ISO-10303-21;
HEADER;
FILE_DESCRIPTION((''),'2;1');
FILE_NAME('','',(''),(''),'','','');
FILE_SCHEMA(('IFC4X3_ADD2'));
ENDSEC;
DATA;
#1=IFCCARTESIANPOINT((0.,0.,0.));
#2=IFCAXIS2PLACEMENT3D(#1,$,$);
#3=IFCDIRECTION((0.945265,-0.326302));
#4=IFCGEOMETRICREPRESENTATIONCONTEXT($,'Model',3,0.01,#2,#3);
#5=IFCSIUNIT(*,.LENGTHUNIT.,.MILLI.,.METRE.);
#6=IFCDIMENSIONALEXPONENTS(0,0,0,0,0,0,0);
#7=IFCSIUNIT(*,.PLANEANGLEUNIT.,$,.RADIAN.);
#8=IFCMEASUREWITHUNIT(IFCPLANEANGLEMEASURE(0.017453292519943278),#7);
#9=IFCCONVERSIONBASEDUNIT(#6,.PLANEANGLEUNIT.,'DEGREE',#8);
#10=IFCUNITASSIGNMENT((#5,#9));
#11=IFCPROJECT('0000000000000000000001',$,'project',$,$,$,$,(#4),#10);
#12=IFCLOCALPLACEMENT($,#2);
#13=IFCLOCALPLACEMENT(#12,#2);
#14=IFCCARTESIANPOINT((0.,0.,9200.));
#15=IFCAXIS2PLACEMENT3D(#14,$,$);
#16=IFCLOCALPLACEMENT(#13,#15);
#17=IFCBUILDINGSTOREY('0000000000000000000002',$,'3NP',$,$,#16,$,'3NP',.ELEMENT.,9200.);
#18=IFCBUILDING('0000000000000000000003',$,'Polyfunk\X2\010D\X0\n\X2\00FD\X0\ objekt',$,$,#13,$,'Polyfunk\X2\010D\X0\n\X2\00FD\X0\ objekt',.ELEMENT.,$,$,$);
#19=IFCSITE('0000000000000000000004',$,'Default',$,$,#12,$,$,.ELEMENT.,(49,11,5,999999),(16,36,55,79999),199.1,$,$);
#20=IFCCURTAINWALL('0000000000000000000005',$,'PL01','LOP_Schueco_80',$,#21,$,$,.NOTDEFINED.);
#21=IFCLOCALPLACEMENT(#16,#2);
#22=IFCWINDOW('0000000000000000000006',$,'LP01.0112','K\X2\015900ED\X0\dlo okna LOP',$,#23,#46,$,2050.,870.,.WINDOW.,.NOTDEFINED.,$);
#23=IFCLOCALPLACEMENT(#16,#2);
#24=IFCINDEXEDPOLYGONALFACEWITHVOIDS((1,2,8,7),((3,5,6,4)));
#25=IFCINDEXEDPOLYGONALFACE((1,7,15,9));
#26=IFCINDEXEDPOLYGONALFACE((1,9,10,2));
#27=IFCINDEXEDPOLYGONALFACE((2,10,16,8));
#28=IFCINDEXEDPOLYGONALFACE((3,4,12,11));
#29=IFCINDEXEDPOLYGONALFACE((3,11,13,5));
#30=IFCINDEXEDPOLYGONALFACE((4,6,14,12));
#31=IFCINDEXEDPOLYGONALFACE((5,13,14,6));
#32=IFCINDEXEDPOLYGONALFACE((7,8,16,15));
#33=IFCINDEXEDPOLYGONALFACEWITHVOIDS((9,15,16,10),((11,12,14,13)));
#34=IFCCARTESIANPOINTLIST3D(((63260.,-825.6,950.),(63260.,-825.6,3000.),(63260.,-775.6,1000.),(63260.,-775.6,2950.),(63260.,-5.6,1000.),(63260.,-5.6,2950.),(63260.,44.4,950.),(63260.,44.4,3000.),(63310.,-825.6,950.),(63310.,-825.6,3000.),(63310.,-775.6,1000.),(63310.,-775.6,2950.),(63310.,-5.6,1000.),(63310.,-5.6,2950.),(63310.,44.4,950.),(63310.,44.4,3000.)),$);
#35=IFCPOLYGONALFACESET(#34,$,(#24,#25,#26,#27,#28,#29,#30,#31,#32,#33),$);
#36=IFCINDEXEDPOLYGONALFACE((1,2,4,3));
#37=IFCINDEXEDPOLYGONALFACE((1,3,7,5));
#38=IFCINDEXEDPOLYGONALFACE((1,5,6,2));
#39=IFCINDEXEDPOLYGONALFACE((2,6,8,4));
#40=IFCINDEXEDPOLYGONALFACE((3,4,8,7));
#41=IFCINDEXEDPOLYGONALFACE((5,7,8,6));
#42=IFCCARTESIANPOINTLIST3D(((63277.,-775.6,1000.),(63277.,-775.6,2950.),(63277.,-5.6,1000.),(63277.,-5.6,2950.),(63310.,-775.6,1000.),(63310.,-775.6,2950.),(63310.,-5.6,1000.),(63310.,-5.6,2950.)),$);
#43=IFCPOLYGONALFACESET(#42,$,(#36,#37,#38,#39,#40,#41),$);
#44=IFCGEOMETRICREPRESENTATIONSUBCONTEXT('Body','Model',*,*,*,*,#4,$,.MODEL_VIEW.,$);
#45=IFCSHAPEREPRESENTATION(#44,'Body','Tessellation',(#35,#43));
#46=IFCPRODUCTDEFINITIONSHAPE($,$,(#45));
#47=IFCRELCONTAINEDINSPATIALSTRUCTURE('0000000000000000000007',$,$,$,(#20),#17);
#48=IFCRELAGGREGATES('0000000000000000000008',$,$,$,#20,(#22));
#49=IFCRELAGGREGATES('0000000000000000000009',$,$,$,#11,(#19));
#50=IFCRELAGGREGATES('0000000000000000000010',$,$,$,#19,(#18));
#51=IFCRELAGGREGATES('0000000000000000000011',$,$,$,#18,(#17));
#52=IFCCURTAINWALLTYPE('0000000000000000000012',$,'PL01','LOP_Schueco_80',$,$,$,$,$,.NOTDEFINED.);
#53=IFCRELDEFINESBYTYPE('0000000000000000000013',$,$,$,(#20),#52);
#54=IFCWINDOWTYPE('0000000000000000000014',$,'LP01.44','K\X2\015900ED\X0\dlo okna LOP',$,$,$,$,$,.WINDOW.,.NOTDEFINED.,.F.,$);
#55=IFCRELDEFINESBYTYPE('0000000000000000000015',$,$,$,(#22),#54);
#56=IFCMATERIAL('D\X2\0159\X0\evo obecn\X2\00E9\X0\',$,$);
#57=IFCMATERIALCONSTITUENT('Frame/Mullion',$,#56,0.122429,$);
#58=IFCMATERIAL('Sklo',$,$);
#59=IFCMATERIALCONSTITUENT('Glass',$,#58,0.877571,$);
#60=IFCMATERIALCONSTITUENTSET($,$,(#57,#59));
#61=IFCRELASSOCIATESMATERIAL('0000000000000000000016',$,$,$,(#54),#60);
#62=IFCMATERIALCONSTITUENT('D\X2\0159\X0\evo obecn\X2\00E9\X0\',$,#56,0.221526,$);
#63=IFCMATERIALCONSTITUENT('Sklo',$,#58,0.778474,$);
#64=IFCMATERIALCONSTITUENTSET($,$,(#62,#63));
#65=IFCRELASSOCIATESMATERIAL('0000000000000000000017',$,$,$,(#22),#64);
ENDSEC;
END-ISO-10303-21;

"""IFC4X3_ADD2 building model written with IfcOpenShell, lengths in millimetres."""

from ifc_helpers import new_model, entity, si_unit, converted_unit, direction, frame, origin, origin_2d_with_axis, place, context, subcontext, project, spatial, polyline, rectangle, outline, extrude, source, transform, mapped, material, constituent, constituent_set, type_object, type_shapes, element, aggregate, save


model = new_model("IFC4X3_ADD2")

# Units and contexts
model_context = context("Model", 3, precision=0.01, world=origin(), true_north=direction((0.945265, -0.326302)))
body_context = subcontext(model_context, "Body", "Model", "MODEL_VIEW")
ifc_project = project(units=[si_unit("LENGTHUNIT", "METRE", prefix="MILLI"), converted_unit("PLANEANGLEUNIT", "DEGREE", entity("IfcPlaneAngleMeasure", 0.017453292519943278), si_unit("PLANEANGLEUNIT", "RADIAN"), dimensions=[0, 0, 0, 0, 0, 0, 0])], contexts=[model_context])

# Site, building, storey
site_placement = place(None, origin())
site = spatial("IfcSite", under=ifc_project, at=site_placement, Name="Default", CompositionType="ELEMENT", RefLatitude=(49, 11, 5, 999999), RefLongitude=(16, 36, 55, 79999), RefElevation=199.1)
building_placement = place(site_placement, origin())
building = spatial("IfcBuilding", under=site, at=building_placement, Name="Polyfunkčný objekt", LongName="Polyfunkčný objekt", CompositionType="ELEMENT")
storey_placement = place(building_placement, frame((0.0, 0.0, 9200.0)))
storey = spatial("IfcBuildingStorey", under=building, at=storey_placement, Name="3NP", LongName="3NP", CompositionType="ELEMENT", Elevation=9200.0)

# Curtain wall, window
curtain_wall_type = type_object("IfcCurtainWallType", Name="PL01", Description="LOP_Schueco_80", PredefinedType="NOTDEFINED")
curtain_wall_placement = place(storey_placement, frame((0.0, 0.0, -9200.0)))
curtain_wall = element("IfcCurtainWall", 1, at=curtain_wall_placement, inside=storey, type_object=curtain_wall_type, Name="PL01", Description="LOP_Schueco_80", PredefinedType="NOTDEFINED")
ifc_material_1 = material(Name="Sklo")
ifc_material_2 = material(Name="Dřevo obecné")
ifc_constituent_1 = constituent(ifc_material_2, Name="Dřevo obecné", fraction=0.221526)
ifc_constituent_2 = constituent(ifc_material_1, Name="Sklo", fraction=0.778474)
ifc_constituent_set_1 = constituent_set(constituents=[ifc_constituent_1, ifc_constituent_2])
ifc_constituent_3 = constituent(ifc_material_2, Name="Frame/Mullion", fraction=0.122429)
ifc_constituent_4 = constituent(ifc_material_1, Name="Glass", fraction=0.877571)
ifc_constituent_set_2 = constituent_set(constituents=[ifc_constituent_3, ifc_constituent_4])
window_type = type_object("IfcWindowType", Name="LP01.44", Description="Křídlo okna LOP", ParameterTakesPrecedence=False, PartitioningType="NOTDEFINED", PredefinedType="WINDOW", material=ifc_constituent_set_2)
shared_shape_1 = source(origin(), body_context, "Body", "SweptSolid", [
    extrude(outline(polyline([(-1025.0, -435.0), (1025.0, -435.0), (1025.0, 435.0), (-1025.0, 435.0), (-1025.0, -435.0)]), holes=[polyline([(-975.0, -385.0), (-975.0, 385.0), (975.0, 385.0), (975.0, -385.0), (-975.0, -385.0)])]), frame((0.0, 0.0, 1025.0), z_axis=(0.0, 1.0, 0.0), x_axis=(0.0, 0.0, -1.0)), (0.0, 0.0, 1.0), 50.0),
    extrude(rectangle(XDim=33.0, YDim=770.0, at=origin_2d_with_axis()), frame((0.0, 33.5, 50.0), z_axis=(0.0, 0.0, 1.0), x_axis=(0.0, -1.0, 0.0)), (0.0, 0.0, 1.0), 1950.0),
])
type_shapes(window_type, [shared_shape_1])
window_placement = place(curtain_wall_placement, frame((63260.0, -390.6, 10150.0), z_axis=(0.0, 0.0, 1.0), x_axis=(0.0, -1.0, 0.0)))
window = element("IfcWindow", 2, at=window_placement, type_object=window_type, material=ifc_constituent_set_1, Name="LP01.0112", Description="Křídlo okna LOP", OverallHeight=2050.0, OverallWidth=870.0, PartitioningType="NOTDEFINED", PredefinedType="WINDOW", context=body_context, shape_type="MappedRepresentation", body=[
    mapped(shared_shape_1, transform((0.0, 0.0, 0.0), scale=1.0)),
])
aggregate(curtain_wall, [window])

save(model, "model.ifc")
